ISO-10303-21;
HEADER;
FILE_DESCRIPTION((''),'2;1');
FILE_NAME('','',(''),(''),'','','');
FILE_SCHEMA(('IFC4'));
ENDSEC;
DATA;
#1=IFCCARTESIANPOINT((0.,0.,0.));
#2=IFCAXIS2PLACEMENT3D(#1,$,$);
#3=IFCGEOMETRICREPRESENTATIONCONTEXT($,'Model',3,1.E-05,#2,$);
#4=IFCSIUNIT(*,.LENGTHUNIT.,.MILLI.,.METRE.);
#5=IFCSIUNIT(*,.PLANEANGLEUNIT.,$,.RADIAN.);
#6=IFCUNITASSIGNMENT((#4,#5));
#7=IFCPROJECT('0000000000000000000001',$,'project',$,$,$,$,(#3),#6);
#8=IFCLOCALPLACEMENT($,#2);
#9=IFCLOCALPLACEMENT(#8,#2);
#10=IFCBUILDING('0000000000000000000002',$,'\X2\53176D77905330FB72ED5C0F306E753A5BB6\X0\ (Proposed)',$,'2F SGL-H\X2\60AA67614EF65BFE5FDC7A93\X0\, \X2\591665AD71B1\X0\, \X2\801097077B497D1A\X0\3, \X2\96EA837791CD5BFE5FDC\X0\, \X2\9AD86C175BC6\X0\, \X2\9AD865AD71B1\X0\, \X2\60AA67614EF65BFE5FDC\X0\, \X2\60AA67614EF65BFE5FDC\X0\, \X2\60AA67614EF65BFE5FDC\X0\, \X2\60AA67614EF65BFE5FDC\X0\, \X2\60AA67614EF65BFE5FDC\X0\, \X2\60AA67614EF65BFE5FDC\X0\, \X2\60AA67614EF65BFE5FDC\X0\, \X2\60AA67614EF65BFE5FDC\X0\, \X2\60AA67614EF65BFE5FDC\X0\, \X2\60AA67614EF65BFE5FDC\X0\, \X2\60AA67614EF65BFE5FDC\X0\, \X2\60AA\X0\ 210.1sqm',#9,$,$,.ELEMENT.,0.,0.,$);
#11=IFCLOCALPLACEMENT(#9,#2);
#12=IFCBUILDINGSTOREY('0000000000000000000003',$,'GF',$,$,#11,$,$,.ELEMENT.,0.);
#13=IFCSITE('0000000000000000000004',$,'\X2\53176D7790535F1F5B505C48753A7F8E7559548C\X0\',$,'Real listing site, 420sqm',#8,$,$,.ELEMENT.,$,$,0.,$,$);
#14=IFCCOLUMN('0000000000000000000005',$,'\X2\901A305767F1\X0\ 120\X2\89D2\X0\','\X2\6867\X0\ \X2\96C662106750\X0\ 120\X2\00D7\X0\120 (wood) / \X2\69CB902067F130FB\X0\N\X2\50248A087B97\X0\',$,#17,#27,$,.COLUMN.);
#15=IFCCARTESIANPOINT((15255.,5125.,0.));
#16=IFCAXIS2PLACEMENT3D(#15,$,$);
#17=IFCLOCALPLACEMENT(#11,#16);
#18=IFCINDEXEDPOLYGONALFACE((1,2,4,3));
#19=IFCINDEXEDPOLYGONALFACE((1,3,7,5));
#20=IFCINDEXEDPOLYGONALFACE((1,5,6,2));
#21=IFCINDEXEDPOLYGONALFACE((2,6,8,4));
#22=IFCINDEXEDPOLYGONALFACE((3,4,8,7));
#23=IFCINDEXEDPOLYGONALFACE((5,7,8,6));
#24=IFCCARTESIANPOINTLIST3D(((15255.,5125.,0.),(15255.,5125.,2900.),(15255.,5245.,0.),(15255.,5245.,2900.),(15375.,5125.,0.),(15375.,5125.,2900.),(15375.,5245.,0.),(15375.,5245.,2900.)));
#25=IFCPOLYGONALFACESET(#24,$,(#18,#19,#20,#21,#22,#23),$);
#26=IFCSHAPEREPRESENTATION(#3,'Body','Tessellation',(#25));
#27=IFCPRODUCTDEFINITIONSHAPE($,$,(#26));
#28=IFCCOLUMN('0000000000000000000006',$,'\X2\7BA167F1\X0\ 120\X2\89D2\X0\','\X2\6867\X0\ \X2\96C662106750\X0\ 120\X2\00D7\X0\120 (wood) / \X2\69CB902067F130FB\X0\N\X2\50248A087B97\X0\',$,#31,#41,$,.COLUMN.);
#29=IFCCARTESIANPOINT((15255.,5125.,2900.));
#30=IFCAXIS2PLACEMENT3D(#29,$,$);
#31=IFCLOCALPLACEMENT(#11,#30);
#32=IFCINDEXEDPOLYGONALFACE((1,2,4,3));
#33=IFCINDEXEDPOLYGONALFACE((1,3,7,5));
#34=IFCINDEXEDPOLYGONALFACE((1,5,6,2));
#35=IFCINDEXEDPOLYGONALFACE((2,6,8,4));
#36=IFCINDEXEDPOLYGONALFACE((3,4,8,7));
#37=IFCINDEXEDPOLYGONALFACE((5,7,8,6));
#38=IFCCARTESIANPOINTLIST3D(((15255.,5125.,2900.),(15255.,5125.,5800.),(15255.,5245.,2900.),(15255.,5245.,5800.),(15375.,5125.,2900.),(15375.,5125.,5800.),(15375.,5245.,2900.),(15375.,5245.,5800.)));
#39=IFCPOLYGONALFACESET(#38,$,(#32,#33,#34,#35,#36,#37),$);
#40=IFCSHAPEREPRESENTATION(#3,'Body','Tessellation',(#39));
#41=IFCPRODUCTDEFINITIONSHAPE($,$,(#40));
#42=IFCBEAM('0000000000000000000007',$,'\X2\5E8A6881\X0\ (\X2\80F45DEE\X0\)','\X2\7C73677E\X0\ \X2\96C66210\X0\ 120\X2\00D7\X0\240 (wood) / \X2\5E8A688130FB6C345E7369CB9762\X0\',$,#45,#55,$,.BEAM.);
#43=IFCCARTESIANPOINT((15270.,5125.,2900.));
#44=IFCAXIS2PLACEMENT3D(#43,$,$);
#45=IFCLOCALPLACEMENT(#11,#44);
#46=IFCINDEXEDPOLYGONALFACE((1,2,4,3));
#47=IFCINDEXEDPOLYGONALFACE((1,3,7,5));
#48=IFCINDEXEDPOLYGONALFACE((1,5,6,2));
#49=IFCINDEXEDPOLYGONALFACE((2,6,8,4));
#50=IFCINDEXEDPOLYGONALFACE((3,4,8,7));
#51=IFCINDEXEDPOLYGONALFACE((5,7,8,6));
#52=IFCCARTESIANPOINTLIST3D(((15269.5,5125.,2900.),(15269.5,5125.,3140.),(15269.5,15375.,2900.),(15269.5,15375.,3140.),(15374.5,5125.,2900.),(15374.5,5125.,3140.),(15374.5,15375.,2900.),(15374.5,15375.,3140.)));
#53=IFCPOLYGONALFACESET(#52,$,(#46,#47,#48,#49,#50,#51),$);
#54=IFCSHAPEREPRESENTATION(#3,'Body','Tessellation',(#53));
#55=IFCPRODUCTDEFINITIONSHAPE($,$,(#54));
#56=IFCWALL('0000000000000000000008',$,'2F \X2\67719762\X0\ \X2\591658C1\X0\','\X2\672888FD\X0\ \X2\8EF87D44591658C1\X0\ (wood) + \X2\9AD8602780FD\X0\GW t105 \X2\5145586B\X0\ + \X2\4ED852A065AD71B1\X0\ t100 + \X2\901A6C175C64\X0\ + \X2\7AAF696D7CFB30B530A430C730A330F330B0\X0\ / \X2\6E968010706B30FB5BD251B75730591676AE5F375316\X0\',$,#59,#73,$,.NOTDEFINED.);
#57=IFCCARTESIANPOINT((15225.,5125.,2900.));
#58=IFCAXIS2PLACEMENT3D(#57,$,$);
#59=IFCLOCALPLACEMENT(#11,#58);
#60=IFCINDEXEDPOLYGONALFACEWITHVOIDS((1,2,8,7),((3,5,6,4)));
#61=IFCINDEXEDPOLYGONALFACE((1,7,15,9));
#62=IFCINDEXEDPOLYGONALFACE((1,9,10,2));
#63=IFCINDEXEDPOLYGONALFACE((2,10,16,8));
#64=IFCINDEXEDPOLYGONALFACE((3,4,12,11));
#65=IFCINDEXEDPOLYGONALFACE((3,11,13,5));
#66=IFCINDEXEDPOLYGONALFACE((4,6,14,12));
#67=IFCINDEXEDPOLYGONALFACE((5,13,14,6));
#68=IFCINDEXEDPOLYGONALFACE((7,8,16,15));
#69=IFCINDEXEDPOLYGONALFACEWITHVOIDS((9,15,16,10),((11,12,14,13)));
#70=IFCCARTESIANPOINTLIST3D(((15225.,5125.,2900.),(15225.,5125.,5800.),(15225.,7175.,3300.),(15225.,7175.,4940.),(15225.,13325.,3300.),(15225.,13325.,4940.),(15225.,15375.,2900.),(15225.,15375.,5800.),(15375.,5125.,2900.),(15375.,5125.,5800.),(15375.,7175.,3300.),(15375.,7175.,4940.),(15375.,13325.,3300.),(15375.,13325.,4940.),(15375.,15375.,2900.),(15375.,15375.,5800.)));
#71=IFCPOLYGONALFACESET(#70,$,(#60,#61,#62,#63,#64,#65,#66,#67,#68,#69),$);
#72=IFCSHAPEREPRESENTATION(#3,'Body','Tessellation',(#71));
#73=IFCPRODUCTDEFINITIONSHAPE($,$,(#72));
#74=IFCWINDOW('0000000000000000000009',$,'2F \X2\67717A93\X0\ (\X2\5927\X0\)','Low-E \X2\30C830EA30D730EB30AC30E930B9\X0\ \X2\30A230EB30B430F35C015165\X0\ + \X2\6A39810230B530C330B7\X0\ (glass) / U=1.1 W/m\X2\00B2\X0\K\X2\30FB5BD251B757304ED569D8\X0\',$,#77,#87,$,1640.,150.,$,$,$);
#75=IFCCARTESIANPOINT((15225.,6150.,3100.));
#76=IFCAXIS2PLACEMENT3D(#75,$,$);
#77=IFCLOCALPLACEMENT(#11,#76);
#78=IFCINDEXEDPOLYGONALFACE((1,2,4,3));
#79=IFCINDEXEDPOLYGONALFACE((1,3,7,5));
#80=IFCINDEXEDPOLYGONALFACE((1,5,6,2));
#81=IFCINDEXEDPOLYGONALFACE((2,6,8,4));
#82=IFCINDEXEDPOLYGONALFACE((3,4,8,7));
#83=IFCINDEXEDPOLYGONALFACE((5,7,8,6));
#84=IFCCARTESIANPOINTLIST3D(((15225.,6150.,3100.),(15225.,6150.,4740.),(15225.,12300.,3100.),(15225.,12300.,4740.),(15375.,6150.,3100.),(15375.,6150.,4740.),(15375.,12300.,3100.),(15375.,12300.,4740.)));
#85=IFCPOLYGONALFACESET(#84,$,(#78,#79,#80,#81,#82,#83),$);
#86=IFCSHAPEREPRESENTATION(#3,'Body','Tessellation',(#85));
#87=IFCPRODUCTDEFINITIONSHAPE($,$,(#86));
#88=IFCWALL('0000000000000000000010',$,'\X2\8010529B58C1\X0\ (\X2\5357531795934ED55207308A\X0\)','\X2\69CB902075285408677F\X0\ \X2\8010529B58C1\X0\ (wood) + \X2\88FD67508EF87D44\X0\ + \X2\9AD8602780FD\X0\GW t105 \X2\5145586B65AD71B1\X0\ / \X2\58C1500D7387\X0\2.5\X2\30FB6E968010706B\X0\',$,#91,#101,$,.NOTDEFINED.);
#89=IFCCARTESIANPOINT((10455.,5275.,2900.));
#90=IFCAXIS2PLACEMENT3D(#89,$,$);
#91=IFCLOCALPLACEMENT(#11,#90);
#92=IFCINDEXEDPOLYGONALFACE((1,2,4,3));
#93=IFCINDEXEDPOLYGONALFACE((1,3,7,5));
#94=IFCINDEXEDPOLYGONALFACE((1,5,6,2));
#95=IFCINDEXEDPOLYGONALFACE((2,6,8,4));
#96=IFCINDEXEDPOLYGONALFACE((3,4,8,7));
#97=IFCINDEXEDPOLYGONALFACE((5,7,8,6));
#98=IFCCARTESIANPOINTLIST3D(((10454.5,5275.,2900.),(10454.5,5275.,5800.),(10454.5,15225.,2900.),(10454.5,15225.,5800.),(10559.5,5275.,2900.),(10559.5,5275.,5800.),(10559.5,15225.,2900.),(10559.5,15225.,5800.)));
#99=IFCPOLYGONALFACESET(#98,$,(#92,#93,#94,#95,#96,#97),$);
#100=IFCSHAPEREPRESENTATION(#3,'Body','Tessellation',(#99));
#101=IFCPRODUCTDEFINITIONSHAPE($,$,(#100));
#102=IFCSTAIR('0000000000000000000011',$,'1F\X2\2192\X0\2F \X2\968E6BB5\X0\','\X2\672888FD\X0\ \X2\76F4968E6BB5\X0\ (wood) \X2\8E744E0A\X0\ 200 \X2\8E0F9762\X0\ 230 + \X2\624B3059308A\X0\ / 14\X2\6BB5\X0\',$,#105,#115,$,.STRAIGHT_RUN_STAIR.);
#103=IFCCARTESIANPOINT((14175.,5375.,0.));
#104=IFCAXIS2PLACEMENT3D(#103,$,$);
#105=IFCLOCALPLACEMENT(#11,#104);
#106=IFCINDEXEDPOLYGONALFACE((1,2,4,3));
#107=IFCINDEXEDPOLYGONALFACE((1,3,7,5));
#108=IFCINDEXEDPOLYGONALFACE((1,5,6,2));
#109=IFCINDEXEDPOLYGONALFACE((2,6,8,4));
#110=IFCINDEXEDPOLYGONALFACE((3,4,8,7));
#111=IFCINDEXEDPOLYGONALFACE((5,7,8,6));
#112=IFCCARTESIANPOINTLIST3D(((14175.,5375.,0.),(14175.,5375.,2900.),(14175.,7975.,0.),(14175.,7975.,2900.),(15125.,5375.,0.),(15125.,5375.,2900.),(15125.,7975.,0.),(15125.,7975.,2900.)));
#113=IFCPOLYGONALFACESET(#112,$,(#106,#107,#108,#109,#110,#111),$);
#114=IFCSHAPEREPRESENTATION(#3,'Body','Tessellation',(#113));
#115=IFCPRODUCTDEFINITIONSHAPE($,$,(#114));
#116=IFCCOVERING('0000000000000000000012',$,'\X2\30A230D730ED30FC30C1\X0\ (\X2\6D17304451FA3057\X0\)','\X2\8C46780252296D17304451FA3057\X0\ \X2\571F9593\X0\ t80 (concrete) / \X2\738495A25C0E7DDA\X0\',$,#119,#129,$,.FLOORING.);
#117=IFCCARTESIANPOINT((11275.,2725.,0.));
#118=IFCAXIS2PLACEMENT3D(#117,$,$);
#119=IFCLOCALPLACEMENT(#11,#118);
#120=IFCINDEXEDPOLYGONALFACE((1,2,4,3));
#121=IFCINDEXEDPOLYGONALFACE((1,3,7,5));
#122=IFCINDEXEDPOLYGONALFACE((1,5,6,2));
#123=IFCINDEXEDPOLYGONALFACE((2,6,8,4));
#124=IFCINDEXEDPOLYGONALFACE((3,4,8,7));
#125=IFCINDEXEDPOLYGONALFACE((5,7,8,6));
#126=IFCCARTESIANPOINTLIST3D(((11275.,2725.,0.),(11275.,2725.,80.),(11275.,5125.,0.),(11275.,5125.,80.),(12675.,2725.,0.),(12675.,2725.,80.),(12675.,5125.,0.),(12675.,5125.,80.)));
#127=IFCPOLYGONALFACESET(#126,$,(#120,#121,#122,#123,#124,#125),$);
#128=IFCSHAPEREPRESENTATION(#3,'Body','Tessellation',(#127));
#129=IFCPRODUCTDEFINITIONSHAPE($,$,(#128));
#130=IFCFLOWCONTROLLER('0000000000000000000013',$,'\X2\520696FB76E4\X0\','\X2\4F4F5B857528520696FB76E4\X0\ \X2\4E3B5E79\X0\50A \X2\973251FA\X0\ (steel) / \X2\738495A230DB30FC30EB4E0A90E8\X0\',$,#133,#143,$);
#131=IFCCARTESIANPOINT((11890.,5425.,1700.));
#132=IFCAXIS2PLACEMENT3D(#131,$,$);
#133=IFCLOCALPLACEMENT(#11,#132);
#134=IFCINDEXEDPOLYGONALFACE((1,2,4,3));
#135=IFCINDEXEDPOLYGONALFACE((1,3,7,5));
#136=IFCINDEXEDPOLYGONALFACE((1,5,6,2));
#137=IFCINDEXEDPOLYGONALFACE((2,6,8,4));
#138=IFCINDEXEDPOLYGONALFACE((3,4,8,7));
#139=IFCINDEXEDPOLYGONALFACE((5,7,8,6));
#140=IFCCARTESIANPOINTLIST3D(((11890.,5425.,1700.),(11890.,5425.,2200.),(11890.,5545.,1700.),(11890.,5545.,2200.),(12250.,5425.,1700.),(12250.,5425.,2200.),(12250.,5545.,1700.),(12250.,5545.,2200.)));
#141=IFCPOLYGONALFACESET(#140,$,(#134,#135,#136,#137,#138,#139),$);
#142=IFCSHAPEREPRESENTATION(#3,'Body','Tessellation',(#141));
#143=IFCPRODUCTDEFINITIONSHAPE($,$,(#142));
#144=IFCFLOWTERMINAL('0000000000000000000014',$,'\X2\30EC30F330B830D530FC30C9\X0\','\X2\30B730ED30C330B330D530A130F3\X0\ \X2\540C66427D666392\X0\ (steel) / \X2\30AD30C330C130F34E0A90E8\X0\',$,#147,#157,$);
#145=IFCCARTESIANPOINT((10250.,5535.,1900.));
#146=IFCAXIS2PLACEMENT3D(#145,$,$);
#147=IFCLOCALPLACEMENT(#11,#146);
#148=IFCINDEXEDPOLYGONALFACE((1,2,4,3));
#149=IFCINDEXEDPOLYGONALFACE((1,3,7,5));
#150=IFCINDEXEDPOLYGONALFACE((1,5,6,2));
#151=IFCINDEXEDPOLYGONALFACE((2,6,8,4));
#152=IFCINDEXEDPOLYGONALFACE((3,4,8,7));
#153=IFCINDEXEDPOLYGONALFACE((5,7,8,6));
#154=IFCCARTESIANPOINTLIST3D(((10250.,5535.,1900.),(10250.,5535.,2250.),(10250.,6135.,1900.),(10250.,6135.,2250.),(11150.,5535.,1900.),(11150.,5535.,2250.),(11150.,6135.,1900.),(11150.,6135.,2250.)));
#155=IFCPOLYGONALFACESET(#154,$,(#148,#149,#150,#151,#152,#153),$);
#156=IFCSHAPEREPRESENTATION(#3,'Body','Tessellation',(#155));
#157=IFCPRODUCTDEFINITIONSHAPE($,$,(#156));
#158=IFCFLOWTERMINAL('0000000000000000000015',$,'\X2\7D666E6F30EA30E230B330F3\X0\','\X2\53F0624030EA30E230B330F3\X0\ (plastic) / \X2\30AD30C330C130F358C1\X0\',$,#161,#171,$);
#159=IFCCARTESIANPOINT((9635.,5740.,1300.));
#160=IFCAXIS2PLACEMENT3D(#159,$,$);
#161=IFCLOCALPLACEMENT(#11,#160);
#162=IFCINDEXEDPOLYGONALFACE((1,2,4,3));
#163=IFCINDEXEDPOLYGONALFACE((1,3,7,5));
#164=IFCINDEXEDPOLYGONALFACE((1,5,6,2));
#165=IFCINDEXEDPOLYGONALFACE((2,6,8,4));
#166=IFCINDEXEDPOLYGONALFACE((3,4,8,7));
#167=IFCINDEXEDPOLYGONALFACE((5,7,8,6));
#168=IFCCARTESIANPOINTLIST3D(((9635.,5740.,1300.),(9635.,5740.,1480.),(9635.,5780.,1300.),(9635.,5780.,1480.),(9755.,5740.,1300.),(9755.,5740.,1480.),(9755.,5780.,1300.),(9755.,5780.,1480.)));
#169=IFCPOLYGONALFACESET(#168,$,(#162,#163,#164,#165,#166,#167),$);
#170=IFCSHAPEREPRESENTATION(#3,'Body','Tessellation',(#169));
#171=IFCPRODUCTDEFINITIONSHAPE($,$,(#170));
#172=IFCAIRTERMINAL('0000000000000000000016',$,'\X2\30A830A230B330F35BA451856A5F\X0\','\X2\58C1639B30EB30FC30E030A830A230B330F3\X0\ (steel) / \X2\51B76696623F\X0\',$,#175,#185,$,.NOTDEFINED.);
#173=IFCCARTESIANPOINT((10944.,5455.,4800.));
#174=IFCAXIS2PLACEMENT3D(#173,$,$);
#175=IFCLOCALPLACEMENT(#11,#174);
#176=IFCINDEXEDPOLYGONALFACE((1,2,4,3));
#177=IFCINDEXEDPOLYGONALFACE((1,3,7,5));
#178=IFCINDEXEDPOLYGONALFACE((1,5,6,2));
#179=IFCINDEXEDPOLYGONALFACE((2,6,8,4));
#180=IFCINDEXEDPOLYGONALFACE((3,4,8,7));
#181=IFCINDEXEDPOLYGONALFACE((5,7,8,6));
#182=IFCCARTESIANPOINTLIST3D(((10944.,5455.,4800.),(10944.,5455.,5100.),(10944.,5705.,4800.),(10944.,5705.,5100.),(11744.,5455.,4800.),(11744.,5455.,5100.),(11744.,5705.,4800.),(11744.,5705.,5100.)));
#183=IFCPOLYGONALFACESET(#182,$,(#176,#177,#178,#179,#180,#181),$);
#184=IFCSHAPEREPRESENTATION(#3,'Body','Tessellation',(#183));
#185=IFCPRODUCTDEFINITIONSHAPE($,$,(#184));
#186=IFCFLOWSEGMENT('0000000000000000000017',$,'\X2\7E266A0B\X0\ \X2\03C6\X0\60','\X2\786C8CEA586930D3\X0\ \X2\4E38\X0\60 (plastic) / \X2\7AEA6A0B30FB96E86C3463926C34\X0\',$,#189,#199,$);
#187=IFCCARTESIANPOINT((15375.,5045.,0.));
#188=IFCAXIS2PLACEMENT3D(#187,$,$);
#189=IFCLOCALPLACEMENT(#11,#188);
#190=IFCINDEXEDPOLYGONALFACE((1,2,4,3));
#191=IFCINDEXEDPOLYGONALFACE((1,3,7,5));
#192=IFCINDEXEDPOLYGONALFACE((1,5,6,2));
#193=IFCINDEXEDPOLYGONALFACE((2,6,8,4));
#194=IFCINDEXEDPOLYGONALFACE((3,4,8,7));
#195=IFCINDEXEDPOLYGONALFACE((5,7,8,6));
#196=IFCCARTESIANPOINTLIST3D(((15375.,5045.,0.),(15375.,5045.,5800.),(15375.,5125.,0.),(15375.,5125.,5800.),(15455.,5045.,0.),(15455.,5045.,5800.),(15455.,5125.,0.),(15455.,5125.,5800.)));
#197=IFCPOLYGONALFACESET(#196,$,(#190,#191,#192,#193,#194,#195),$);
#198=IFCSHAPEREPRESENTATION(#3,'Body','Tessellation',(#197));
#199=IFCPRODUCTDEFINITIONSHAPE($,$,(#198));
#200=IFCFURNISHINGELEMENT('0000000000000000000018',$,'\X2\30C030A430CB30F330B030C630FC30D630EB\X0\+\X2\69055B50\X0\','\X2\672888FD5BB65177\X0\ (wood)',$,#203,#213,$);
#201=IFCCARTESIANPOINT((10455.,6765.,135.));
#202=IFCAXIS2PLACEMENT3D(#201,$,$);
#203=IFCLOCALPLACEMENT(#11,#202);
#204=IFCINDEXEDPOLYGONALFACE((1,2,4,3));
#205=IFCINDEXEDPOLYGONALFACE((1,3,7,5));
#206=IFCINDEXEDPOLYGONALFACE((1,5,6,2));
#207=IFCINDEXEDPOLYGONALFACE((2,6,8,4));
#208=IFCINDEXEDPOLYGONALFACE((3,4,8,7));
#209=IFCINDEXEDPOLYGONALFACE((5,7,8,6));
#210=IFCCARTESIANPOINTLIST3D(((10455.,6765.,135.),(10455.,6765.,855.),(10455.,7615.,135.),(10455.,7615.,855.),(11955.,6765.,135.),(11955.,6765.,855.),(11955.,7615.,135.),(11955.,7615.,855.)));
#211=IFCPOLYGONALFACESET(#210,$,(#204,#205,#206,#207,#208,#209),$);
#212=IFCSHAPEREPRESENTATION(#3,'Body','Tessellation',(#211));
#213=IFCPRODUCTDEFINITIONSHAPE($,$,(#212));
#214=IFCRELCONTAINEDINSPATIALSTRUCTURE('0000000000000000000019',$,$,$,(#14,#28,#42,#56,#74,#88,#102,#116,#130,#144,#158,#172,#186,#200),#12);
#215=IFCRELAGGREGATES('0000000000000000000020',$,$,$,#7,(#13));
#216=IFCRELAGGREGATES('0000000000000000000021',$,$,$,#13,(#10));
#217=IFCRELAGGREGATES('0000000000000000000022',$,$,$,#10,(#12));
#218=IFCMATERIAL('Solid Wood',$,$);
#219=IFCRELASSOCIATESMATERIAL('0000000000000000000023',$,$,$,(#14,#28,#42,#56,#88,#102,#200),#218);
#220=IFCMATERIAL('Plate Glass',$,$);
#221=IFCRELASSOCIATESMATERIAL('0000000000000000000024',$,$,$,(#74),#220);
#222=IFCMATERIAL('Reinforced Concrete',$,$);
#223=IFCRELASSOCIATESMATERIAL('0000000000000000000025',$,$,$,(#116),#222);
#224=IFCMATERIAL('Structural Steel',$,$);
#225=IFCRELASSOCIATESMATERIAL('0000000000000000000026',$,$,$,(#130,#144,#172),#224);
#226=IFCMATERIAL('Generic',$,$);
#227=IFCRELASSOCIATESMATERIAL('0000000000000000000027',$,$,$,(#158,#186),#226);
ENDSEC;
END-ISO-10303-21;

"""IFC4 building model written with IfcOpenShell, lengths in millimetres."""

from ifc_helpers import new_model, si_unit, frame, frame_2d, origin, place, context, project, spatial, rectangle, extrude, material, element, fill, save


model = new_model("IFC4")

# Units and contexts
model_context = context("Model", 3, precision=1e-05, world=origin())
ifc_project = project(units=[si_unit("LENGTHUNIT", "METRE", prefix="MILLI"), si_unit("PLANEANGLEUNIT", "RADIAN")], contexts=[model_context])

# Site, building, storey
site_placement = place(None, origin())
site = spatial("IfcSite", under=ifc_project, at=site_placement, Name="北海道弟子屈町美留和", ObjectType="Real listing site, 420sqm", CompositionType="ELEMENT", RefElevation=0.0)
building_placement = place(site_placement, origin())
building = spatial("IfcBuilding", under=site, at=building_placement, Name="北海道・狭小の町家 (Proposed)", ObjectType="2F SGL-H悪条件対応窓, 外断熱, 耐震等級3, 雪荷重対応, 高気密, 高断熱, 悪条件対応, 悪条件対応, 悪条件対応, 悪条件対応, 悪条件対応, 悪条件対応, 悪条件対応, 悪条件対応, 悪条件対応, 悪条件対応, 悪条件対応, 悪 210.1sqm", CompositionType="ELEMENT", ElevationOfRefHeight=0.0, ElevationOfTerrain=0.0)
storey_placement = place(building_placement, origin())
storey = spatial("IfcBuildingStorey", under=building, at=storey_placement, Name="GF", CompositionType="ELEMENT", Elevation=0.0)

# Columns
ifc_material_1 = material(Name="Solid Wood")
column_1_placement = place(storey_placement, frame((15255.0, 5125.0, 0.0)))
element("IfcColumn", 1, at=column_1_placement, inside=storey, material=ifc_material_1, Name="通し柱 120角", Description="桧 集成材 120×120 (wood) / 構造柱・N値計算", PredefinedType="COLUMN", context=model_context, shape_type="SweptSolid", body=[
    extrude(rectangle(XDim=120.0, YDim=120.0, at=frame_2d((60.0, 60.0))), frame((15255.0, 5125.0, 0.0)), (0.0, 0.0, 1.0), 2900.0),
])
column_2_placement = place(storey_placement, frame((15255.0, 5125.0, 2900.0)))
element("IfcColumn", 2, at=column_2_placement, inside=storey, material=ifc_material_1, Name="管柱 120角", Description="桧 集成材 120×120 (wood) / 構造柱・N値計算", PredefinedType="COLUMN", context=model_context, shape_type="SweptSolid", body=[
    extrude(rectangle(XDim=120.0, YDim=120.0, at=frame_2d((60.0, 60.0))), frame((15255.0, 5125.0, 2900.0)), (0.0, 0.0, 1.0), 2900.0),
])

# Beam
beam_1_placement = place(storey_placement, frame((15270.0, 5125.0, 2900.0)))
element("IfcBeam", 3, at=beam_1_placement, inside=storey, material=ifc_material_1, Name="床梁 (胴差)", Description="米松 集成 120×240 (wood) / 床梁・水平構面", PredefinedType="BEAM", context=model_context, shape_type="SweptSolid", body=[
    extrude(rectangle(XDim=105.0, YDim=10250.0, at=frame_2d((52.0, 5125.0))), frame((15270.0, 5125.0, 2900.0)), (0.0, 0.0, 1.0), 240.0),
])

# Shared definitions
ifc_material_2 = material(Name="Plate Glass")

# Wall, opening, window
wall_1_placement = place(storey_placement, frame((15225.0, 5125.0, 2900.0)))
wall_1 = element("IfcWall", 4, at=wall_1_placement, inside=storey, material=ifc_material_1, Name="2F 東面 外壁", Description="木製 軸組外壁 (wood) + 高性能GW t105 充填 + 付加断熱 t100 + 通気層 + 窯業系サイディング / 準耐火・寒冷地外皮強化", PredefinedType="NOTDEFINED", context=model_context, shape_type="SweptSolid", body=[
    extrude(rectangle(XDim=150.0, YDim=10250.0, at=frame_2d((75.0, 5125.0))), frame((15225.0, 5125.0, 2900.0)), (0.0, 0.0, 1.0), 2900.0),
])
opening_1_placement = place(storey_placement, frame((15225.0, 6150.0, 3100.0)))
opening_1 = element("IfcOpeningElement", 5, at=opening_1_placement, cuts=wall_1, PredefinedType="NOTDEFINED", context=model_context, shape_type="SweptSolid", body=[
    extrude(rectangle(XDim=150.0, YDim=6150.0, at=frame_2d((75.0, 3075.0))), frame((15225.0, 6150.0, 3100.0)), (0.0, 0.0, 1.0), 1640.0),
])
window_1_placement = place(storey_placement, frame((15225.0, 6150.0, 3100.0)))
window_1 = element("IfcWindow", 6, at=window_1_placement, inside=storey, material=ifc_material_2, Name="2F 東窓 (大)", Description="Low-E トリプルガラス アルゴン封入 + 樹脂サッシ (glass) / U=1.1 W/m²K・寒冷地仕様", OverallHeight=1640.0, OverallWidth=150.0, context=model_context, shape_type="SweptSolid", body=[
    extrude(rectangle(XDim=150.0, YDim=6150.0, at=frame_2d((75.0, 3075.0))), frame((15225.0, 6150.0, 3100.0)), (0.0, 0.0, 1.0), 1640.0),
])
fill(opening_1, window_1)

# Wall
wall_2_placement = place(storey_placement, frame((10455.0, 5275.0, 2900.0)))
element("IfcWall", 7, at=wall_2_placement, inside=storey, material=ifc_material_1, Name="耐力壁 (南北間仕切り)", Description="構造用合板 耐力壁 (wood) + 製材軸組 + 高性能GW t105 充填断熱 / 壁倍率2.5・準耐火", PredefinedType="NOTDEFINED", context=model_context, shape_type="SweptSolid", body=[
    extrude(rectangle(XDim=105.0, YDim=9950.0, at=frame_2d((52.0, 4975.0))), frame((10455.0, 5275.0, 2900.0)), (0.0, 0.0, 1.0), 2900.0),
])

# Stair
stair_placement = place(storey_placement, frame((14175.0, 5375.0, 0.0)))
element("IfcStair", 8, at=stair_placement, inside=storey, material=ifc_material_1, Name="1F→2F 階段", Description="木製 直階段 (wood) 蹴上 200 踏面 230 + 手すり / 14段", PredefinedType="STRAIGHT_RUN_STAIR", context=model_context, shape_type="SweptSolid", body=[
    extrude(rectangle(XDim=950.0, YDim=2600.0, at=frame_2d((475.0, 1300.0))), frame((14175.0, 5375.0, 0.0)), (0.0, 0.0, 1.0), 2900.0),
])

# Covering
ifc_material_3 = material(Name="Reinforced Concrete")
covering_placement = place(storey_placement, frame((11275.0, 2725.0, 0.0)))
element("IfcCovering", 9, at=covering_placement, inside=storey, material=ifc_material_3, Name="アプローチ (洗い出し)", Description="豆砂利洗い出し 土間 t80 (concrete) / 玄関導線", PredefinedType="FLOORING", context=model_context, shape_type="SweptSolid", body=[
    extrude(rectangle(XDim=1400.0, YDim=2400.0, at=frame_2d((700.0, 1200.0))), frame((11275.0, 2725.0, 0.0)), (0.0, 0.0, 1.0), 80.0),
])

# Flow controller
ifc_material_4 = material(Name="Structural Steel")
flow_controller_placement = place(storey_placement, frame((11890.0, 5425.0, 1700.0)))
element("IfcFlowController", 10, at=flow_controller_placement, inside=storey, material=ifc_material_4, Name="分電盤", Description="住宅用分電盤 主幹50A 露出 (steel) / 玄関ホール上部", context=model_context, shape_type="SweptSolid", body=[
    extrude(rectangle(XDim=360.0, YDim=120.0, at=frame_2d((180.0, 60.0))), frame((11890.0, 5425.0, 1700.0)), (0.0, 0.0, 1.0), 500.0),
])

# Flow terminals
flow_terminal_1_placement = place(storey_placement, frame((10250.0, 5535.0, 1900.0)))
element("IfcFlowTerminal", 11, at=flow_terminal_1_placement, inside=storey, material=ifc_material_4, Name="レンジフード", Description="シロッコファン 同時給排 (steel) / キッチン上部", context=model_context, shape_type="SweptSolid", body=[
    extrude(rectangle(XDim=900.0, YDim=600.0, at=frame_2d((450.0, 300.0))), frame((10250.0, 5535.0, 1900.0)), (0.0, 0.0, 1.0), 350.0),
])
ifc_material_5 = material(Name="Generic")
flow_terminal_2_placement = place(storey_placement, frame((9635.0, 5740.0, 1300.0)))
element("IfcFlowTerminal", 12, at=flow_terminal_2_placement, inside=storey, material=ifc_material_5, Name="給湯リモコン", Description="台所リモコン (plastic) / キッチン壁", context=model_context, shape_type="SweptSolid", body=[
    extrude(rectangle(XDim=120.0, YDim=40.0, at=frame_2d((60.0, 20.0))), frame((9635.0, 5740.0, 1300.0)), (0.0, 0.0, 1.0), 180.0),
])

# Air terminal
air_terminal_placement = place(storey_placement, frame((10944.0, 5455.0, 4800.0)))
element("IfcAirTerminal", 13, at=air_terminal_placement, inside=storey, material=ifc_material_4, Name="エアコン室内機", Description="壁掛ルームエアコン (steel) / 冷暖房", PredefinedType="NOTDEFINED", context=model_context, shape_type="SweptSolid", body=[
    extrude(rectangle(XDim=800.0, YDim=250.0, at=frame_2d((400.0, 125.0))), frame((10944.0, 5455.0, 4800.0)), (0.0, 0.0, 1.0), 300.0),
])

# Flow segment
flow_segment_placement = place(storey_placement, frame((15375.0, 5045.0, 0.0)))
element("IfcFlowSegment", 14, at=flow_segment_placement, inside=storey, material=ifc_material_5, Name="縦樋 φ60", Description="硬質塩ビ 丸60 (plastic) / 竪樋・雨水排水", context=model_context, shape_type="SweptSolid", body=[
    extrude(rectangle(XDim=80.0, YDim=80.0, at=frame_2d((40.0, 40.0))), frame((15375.0, 5045.0, 0.0)), (0.0, 0.0, 1.0), 5800.0),
])

# Furnishing element
furnishing_1_placement = place(storey_placement, frame((10455.0, 6765.0, 135.0)))
element("IfcFurnishingElement", 15, at=furnishing_1_placement, inside=storey, material=ifc_material_1, Name="ダイニングテーブル+椅子", Description="木製家具 (wood)", context=model_context, shape_type="SweptSolid", body=[
    extrude(rectangle(XDim=1500.0, YDim=850.0, at=frame_2d((750.0, 425.0))), frame((10455.0, 6765.0, 135.0)), (0.0, 0.0, 1.0), 720.0),
])

save(model, "model.ifc")
